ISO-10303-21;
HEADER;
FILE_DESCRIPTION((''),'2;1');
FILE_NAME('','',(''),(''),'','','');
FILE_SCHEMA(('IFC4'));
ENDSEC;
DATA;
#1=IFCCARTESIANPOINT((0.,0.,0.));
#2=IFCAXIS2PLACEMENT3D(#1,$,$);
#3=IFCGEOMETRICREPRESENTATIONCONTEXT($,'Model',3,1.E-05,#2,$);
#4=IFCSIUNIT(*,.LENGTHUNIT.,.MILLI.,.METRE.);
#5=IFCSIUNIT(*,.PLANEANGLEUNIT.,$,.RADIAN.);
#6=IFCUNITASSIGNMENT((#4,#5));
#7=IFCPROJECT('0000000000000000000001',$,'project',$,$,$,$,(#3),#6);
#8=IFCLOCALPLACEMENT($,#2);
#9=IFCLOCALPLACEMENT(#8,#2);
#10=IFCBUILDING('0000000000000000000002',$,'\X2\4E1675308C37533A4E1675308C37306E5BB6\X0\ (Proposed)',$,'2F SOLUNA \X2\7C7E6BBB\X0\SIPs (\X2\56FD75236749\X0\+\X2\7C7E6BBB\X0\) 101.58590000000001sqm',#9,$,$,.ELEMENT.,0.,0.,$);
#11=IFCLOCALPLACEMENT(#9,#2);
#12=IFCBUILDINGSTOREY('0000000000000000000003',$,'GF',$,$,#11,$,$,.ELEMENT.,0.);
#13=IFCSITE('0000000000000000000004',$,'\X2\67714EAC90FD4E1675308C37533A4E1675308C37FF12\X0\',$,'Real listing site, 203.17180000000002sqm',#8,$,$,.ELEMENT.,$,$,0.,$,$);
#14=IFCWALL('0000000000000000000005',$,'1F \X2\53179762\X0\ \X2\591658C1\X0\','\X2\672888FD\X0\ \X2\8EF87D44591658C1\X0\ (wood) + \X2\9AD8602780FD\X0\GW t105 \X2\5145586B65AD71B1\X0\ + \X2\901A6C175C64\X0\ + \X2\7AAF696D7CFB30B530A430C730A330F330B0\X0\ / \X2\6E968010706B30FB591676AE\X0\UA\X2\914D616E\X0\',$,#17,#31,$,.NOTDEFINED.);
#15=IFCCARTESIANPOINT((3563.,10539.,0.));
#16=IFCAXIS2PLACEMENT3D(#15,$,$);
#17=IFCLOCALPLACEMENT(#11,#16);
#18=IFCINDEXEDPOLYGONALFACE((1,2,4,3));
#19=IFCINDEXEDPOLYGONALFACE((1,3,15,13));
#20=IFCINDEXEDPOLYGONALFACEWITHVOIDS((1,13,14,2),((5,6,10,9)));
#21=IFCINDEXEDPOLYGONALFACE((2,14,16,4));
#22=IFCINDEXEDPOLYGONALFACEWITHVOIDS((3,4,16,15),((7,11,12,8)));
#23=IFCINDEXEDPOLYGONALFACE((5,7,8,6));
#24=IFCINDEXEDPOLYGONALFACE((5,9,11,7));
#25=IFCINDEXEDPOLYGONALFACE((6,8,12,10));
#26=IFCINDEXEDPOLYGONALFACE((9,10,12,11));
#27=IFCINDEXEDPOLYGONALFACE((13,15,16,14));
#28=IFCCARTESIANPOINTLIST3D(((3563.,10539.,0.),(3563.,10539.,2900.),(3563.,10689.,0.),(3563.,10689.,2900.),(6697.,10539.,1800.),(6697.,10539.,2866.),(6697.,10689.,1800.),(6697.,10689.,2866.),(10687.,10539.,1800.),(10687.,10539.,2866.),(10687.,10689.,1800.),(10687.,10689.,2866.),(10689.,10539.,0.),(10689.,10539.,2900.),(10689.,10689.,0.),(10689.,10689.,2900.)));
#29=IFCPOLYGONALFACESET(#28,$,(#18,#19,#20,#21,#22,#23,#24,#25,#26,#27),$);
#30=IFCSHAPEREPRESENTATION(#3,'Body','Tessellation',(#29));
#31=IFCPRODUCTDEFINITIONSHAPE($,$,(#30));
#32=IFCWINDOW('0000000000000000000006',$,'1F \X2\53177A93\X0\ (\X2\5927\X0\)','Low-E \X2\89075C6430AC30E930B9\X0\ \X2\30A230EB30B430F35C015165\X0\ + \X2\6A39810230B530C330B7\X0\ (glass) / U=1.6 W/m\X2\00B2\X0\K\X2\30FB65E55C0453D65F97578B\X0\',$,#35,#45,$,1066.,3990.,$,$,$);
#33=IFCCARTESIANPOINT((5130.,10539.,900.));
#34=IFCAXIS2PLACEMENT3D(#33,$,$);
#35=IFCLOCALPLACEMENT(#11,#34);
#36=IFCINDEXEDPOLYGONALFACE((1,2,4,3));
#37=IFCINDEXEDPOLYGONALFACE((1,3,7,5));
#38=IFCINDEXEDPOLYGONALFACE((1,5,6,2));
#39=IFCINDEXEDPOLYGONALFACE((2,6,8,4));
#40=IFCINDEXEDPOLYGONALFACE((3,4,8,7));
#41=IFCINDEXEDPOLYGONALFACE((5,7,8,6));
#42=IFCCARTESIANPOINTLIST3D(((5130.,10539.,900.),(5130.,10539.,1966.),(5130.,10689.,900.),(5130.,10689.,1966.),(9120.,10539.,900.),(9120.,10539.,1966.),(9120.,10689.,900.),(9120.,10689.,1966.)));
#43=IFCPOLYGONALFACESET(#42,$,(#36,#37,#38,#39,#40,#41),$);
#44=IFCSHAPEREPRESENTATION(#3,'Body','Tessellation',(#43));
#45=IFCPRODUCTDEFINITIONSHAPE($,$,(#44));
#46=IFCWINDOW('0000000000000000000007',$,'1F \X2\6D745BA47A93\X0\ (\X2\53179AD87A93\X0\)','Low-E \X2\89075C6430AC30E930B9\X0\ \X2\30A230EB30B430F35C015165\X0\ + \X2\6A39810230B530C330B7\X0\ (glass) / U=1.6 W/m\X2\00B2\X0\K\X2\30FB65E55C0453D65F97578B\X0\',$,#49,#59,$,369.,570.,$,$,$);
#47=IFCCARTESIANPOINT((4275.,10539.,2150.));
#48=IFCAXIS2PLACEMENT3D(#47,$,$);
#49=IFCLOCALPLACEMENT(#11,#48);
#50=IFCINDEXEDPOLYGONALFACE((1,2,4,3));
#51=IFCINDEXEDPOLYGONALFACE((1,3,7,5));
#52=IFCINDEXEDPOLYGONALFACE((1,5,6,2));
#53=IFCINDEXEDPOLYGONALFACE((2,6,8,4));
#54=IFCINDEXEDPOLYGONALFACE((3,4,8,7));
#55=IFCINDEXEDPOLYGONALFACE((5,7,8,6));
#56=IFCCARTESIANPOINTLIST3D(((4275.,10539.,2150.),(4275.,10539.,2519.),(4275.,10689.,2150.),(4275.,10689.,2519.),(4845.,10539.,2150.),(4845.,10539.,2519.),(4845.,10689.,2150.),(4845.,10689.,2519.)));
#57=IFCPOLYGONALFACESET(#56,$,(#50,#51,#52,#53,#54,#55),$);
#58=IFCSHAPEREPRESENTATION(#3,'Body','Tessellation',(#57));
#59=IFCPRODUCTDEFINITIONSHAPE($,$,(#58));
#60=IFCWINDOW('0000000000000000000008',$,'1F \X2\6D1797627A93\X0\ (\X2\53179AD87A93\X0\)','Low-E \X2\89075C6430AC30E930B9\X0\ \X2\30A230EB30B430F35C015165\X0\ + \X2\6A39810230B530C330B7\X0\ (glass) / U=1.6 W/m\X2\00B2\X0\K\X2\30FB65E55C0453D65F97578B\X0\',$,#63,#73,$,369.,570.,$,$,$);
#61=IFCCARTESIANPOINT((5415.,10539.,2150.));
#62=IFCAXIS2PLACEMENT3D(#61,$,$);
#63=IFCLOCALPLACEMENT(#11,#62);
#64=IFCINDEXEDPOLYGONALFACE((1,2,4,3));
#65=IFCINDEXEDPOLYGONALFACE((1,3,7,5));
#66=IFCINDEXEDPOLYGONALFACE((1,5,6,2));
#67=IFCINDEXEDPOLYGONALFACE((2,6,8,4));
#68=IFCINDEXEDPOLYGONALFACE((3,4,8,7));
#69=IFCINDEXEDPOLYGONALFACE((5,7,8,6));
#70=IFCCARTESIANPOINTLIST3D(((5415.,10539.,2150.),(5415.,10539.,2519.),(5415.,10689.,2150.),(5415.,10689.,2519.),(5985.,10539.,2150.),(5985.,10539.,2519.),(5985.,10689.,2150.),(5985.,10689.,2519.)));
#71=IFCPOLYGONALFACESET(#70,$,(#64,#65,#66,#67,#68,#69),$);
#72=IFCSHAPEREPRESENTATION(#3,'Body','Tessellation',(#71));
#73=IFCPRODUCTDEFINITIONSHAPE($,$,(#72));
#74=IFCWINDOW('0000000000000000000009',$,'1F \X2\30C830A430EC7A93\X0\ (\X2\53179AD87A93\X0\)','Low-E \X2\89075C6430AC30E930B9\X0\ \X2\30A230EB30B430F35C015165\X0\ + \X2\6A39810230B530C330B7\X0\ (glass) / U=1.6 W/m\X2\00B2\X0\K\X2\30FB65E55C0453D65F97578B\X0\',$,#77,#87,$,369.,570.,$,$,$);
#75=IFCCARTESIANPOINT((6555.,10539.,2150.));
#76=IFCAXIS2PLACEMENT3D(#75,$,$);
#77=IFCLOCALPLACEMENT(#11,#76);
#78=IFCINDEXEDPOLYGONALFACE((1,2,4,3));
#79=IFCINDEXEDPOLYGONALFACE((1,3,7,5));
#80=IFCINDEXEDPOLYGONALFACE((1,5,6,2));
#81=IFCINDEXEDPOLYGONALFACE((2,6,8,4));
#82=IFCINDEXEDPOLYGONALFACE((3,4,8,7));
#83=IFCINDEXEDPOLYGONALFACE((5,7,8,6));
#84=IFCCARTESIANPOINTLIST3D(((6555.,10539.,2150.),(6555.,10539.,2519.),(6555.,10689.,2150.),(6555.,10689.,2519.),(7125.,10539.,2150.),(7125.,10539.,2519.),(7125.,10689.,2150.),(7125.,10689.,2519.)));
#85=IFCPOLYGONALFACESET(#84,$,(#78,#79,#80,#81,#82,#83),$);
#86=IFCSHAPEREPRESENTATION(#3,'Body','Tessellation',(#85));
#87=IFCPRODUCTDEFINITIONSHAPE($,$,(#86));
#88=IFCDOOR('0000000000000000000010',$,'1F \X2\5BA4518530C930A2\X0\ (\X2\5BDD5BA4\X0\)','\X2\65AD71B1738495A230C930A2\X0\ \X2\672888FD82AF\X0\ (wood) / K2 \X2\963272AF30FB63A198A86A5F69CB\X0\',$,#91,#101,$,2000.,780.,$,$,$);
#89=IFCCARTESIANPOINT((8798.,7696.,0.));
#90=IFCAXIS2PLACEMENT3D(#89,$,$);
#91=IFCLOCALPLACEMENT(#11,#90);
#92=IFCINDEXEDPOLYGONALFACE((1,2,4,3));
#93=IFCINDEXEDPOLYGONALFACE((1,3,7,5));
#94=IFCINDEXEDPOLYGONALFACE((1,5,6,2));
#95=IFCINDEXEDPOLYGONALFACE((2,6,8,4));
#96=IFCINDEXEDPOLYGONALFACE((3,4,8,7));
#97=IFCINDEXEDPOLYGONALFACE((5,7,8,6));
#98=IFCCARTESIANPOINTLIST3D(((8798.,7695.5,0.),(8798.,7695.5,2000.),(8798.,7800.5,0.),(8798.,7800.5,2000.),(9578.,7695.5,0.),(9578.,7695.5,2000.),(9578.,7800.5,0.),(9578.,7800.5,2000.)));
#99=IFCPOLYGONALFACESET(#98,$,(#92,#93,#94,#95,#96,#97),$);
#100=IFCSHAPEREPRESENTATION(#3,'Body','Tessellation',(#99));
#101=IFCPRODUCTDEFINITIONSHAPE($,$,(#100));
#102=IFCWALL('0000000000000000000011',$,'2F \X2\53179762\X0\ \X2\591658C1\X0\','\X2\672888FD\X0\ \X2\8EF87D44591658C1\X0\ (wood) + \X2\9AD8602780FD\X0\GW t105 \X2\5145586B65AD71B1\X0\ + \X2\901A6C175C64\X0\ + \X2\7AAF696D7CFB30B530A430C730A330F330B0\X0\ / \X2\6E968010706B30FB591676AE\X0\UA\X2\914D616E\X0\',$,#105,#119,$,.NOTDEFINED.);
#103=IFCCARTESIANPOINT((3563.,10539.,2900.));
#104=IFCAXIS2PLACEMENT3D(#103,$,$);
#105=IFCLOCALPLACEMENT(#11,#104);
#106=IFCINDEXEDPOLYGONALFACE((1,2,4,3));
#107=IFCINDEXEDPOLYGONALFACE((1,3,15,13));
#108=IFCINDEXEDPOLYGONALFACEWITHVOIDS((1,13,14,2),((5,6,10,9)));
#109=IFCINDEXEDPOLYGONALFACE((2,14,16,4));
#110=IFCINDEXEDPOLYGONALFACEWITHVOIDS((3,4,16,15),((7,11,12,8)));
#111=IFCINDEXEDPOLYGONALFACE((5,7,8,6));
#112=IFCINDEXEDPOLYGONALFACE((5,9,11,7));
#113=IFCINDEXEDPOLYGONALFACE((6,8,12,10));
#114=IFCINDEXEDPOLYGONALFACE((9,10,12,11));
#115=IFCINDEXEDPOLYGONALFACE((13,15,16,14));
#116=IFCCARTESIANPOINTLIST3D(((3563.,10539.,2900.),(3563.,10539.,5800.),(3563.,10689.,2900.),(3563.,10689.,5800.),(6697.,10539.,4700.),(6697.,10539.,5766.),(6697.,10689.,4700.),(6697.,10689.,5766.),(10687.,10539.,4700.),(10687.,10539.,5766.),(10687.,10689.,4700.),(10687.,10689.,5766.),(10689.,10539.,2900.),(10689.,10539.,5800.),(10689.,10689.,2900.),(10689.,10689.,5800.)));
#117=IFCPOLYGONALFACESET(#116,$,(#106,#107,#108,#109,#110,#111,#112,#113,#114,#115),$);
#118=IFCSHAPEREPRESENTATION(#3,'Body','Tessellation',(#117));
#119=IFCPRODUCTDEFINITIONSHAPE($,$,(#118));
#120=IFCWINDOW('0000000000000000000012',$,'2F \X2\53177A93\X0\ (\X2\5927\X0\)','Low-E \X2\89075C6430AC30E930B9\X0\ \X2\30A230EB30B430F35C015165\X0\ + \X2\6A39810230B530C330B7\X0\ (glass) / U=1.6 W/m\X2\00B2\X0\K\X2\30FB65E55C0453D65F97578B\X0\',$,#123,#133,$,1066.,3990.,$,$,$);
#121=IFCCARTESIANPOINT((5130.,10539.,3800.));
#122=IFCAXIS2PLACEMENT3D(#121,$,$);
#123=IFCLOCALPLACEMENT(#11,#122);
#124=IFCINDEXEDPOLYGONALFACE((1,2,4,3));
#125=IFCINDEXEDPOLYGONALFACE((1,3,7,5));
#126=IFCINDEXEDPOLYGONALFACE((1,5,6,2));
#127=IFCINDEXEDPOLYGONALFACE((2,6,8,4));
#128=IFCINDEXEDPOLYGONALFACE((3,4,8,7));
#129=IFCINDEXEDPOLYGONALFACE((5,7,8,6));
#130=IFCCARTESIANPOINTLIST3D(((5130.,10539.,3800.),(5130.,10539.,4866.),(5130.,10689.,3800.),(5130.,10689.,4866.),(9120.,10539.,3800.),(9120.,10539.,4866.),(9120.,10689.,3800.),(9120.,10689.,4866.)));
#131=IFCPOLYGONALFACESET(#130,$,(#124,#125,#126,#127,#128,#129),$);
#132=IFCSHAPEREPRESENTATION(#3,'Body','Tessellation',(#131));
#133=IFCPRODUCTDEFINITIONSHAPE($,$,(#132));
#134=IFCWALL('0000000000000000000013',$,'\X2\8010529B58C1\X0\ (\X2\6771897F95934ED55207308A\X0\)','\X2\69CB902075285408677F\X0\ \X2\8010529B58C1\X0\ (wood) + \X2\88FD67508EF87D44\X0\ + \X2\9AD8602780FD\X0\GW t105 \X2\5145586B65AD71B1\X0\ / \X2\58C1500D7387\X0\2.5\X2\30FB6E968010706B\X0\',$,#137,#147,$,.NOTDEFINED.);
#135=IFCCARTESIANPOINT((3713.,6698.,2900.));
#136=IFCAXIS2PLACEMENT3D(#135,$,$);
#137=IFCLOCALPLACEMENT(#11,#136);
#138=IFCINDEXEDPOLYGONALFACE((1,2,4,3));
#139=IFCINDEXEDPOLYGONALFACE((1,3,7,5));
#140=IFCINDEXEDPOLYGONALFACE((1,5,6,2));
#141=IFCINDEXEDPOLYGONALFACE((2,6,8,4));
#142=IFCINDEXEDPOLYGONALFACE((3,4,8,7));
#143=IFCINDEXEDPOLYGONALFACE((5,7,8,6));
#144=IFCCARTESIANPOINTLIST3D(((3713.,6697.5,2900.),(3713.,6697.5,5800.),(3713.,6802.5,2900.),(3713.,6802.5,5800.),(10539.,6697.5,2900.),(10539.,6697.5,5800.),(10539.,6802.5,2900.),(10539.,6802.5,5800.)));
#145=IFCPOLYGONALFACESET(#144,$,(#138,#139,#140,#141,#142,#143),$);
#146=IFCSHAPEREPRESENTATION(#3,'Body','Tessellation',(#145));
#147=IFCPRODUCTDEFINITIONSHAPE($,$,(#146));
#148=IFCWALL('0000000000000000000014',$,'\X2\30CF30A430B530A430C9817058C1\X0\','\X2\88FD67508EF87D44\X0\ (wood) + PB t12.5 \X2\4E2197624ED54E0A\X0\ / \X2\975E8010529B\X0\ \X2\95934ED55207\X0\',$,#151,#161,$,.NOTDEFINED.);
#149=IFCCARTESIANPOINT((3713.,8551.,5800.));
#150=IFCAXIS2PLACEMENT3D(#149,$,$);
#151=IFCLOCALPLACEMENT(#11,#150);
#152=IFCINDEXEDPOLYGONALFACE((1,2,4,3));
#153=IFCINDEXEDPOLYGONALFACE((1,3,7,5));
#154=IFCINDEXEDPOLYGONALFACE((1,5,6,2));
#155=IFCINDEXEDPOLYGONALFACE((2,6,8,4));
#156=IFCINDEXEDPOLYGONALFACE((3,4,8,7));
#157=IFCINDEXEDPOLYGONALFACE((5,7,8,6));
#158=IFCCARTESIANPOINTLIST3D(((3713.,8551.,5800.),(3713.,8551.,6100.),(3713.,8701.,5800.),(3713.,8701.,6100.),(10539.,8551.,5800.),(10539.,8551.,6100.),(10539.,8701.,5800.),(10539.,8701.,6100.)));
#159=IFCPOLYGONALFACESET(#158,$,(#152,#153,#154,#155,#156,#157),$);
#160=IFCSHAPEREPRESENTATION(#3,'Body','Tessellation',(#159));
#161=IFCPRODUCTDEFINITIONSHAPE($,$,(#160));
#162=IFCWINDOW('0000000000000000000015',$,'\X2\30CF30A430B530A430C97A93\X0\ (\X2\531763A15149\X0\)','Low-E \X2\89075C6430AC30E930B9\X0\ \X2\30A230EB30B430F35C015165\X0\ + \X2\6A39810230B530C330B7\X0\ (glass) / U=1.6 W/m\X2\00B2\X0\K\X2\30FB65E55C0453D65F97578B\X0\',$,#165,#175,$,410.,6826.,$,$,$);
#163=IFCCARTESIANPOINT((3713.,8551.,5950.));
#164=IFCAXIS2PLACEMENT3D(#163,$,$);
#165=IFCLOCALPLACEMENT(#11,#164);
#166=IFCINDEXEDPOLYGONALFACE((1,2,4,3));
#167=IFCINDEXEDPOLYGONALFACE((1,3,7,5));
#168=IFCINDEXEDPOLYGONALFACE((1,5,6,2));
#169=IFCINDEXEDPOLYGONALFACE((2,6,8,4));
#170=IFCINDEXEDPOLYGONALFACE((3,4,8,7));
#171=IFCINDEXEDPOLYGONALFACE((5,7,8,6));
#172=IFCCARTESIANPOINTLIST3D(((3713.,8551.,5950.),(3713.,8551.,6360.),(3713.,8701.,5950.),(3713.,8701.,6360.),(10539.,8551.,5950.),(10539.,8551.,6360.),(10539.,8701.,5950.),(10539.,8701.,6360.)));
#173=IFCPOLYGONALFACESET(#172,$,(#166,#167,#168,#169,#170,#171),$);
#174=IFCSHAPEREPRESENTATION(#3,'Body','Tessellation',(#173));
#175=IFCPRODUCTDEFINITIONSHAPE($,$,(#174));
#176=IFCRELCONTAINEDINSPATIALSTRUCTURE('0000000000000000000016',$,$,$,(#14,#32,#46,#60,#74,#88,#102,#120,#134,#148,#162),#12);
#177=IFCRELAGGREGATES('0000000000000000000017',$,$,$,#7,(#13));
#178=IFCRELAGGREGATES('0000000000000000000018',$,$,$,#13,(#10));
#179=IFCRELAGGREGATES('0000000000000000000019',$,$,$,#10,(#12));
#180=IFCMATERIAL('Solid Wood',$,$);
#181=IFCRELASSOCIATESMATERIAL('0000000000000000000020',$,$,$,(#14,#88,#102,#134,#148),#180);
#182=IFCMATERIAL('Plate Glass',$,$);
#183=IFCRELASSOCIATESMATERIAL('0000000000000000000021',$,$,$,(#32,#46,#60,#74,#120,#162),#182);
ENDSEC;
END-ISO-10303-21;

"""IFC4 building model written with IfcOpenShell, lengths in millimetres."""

from ifc_helpers import new_model, si_unit, frame, frame_2d, origin, place, context, project, spatial, rectangle, extrude, material, element, fill, save


model = new_model("IFC4")

# Units and contexts
model_context = context("Model", 3, precision=1e-05, world=origin())
ifc_project = project(units=[si_unit("LENGTHUNIT", "METRE", prefix="MILLI"), si_unit("PLANEANGLEUNIT", "RADIAN")], contexts=[model_context])

# Site, building, storey
site_placement = place(None, origin())
site = spatial("IfcSite", under=ifc_project, at=site_placement, Name="東京都世田谷区世田谷２", ObjectType="Real listing site, 203.17180000000002sqm", CompositionType="ELEMENT", RefElevation=0.0)
building_placement = place(site_placement, origin())
building = spatial("IfcBuilding", under=site, at=building_placement, Name="世田谷区世田谷の家 (Proposed)", ObjectType="2F SOLUNA 籾殻SIPs (国産杉+籾殻) 101.58590000000001sqm", CompositionType="ELEMENT", ElevationOfRefHeight=0.0, ElevationOfTerrain=0.0)
storey_placement = place(building_placement, origin())
storey = spatial("IfcBuildingStorey", under=building, at=storey_placement, Name="GF", CompositionType="ELEMENT", Elevation=0.0)

# Wall, openings, windows
ifc_material_1 = material(Name="Solid Wood")
wall_1_placement = place(storey_placement, frame((3563.0, 10539.0, 0.0)))
wall_1 = element("IfcWall", 1, at=wall_1_placement, inside=storey, material=ifc_material_1, Name="1F 北面 外壁", Description="木製 軸組外壁 (wood) + 高性能GW t105 充填断熱 + 通気層 + 窯業系サイディング / 準耐火・外皮UA配慮", PredefinedType="NOTDEFINED", context=model_context, shape_type="SweptSolid", body=[
    extrude(rectangle(XDim=7126.0, YDim=150.0, at=frame_2d((3563.0, 75.0))), frame((3563.0, 10539.0, 0.0)), (0.0, 0.0, 1.0), 2900.0),
])
opening_1_placement = place(storey_placement, frame((5130.0, 10539.0, 900.0)))
opening_1 = element("IfcOpeningElement", 2, at=opening_1_placement, cuts=wall_1, PredefinedType="NOTDEFINED", context=model_context, shape_type="SweptSolid", body=[
    extrude(rectangle(XDim=3990.0, YDim=150.0, at=frame_2d((1995.0, 75.0))), frame((5130.0, 10539.0, 900.0)), (0.0, 0.0, 1.0), 1066.0),
])
opening_2_placement = place(storey_placement, frame((4275.0, 10539.0, 2150.0)))
opening_2 = element("IfcOpeningElement", 3, at=opening_2_placement, cuts=wall_1, PredefinedType="NOTDEFINED", context=model_context, shape_type="SweptSolid", body=[
    extrude(rectangle(XDim=570.0, YDim=150.0, at=frame_2d((285.0, 75.0))), frame((4275.0, 10539.0, 2150.0)), (0.0, 0.0, 1.0), 369.0),
])
opening_3_placement = place(storey_placement, frame((5415.0, 10539.0, 2150.0)))
opening_3 = element("IfcOpeningElement", 4, at=opening_3_placement, cuts=wall_1, PredefinedType="NOTDEFINED", context=model_context, shape_type="SweptSolid", body=[
    extrude(rectangle(XDim=570.0, YDim=150.0, at=frame_2d((285.0, 75.0))), frame((5415.0, 10539.0, 2150.0)), (0.0, 0.0, 1.0), 369.0),
])
opening_4_placement = place(storey_placement, frame((6555.0, 10539.0, 2150.0)))
opening_4 = element("IfcOpeningElement", 5, at=opening_4_placement, cuts=wall_1, PredefinedType="NOTDEFINED", context=model_context, shape_type="SweptSolid", body=[
    extrude(rectangle(XDim=570.0, YDim=150.0, at=frame_2d((285.0, 75.0))), frame((6555.0, 10539.0, 2150.0)), (0.0, 0.0, 1.0), 369.0),
])
ifc_material_2 = material(Name="Plate Glass")
window_1_placement = place(storey_placement, frame((5130.0, 10539.0, 900.0)))
window_1 = element("IfcWindow", 6, at=window_1_placement, inside=storey, material=ifc_material_2, Name="1F 北窓 (大)", Description="Low-E 複層ガラス アルゴン封入 + 樹脂サッシ (glass) / U=1.6 W/m²K・日射取得型", OverallHeight=1066.0, OverallWidth=3990.0, context=model_context, shape_type="SweptSolid", body=[
    extrude(rectangle(XDim=3990.0, YDim=150.0, at=frame_2d((1995.0, 75.0))), frame((5130.0, 10539.0, 900.0)), (0.0, 0.0, 1.0), 1066.0),
])
fill(opening_1, window_1)
window_2_placement = place(storey_placement, frame((4275.0, 10539.0, 2150.0)))
window_2 = element("IfcWindow", 7, at=window_2_placement, inside=storey, material=ifc_material_2, Name="1F 浴室窓 (北高窓)", Description="Low-E 複層ガラス アルゴン封入 + 樹脂サッシ (glass) / U=1.6 W/m²K・日射取得型", OverallHeight=369.0, OverallWidth=570.0, context=model_context, shape_type="SweptSolid", body=[
    extrude(rectangle(XDim=570.0, YDim=150.0, at=frame_2d((285.0, 75.0))), frame((4275.0, 10539.0, 2150.0)), (0.0, 0.0, 1.0), 369.0),
])
fill(opening_2, window_2)
window_3_placement = place(storey_placement, frame((5415.0, 10539.0, 2150.0)))
window_3 = element("IfcWindow", 8, at=window_3_placement, inside=storey, material=ifc_material_2, Name="1F 洗面窓 (北高窓)", Description="Low-E 複層ガラス アルゴン封入 + 樹脂サッシ (glass) / U=1.6 W/m²K・日射取得型", OverallHeight=369.0, OverallWidth=570.0, context=model_context, shape_type="SweptSolid", body=[
    extrude(rectangle(XDim=570.0, YDim=150.0, at=frame_2d((285.0, 75.0))), frame((5415.0, 10539.0, 2150.0)), (0.0, 0.0, 1.0), 369.0),
])
fill(opening_3, window_3)
window_4_placement = place(storey_placement, frame((6555.0, 10539.0, 2150.0)))
window_4 = element("IfcWindow", 9, at=window_4_placement, inside=storey, material=ifc_material_2, Name="1F トイレ窓 (北高窓)", Description="Low-E 複層ガラス アルゴン封入 + 樹脂サッシ (glass) / U=1.6 W/m²K・日射取得型", OverallHeight=369.0, OverallWidth=570.0, context=model_context, shape_type="SweptSolid", body=[
    extrude(rectangle(XDim=570.0, YDim=150.0, at=frame_2d((285.0, 75.0))), frame((6555.0, 10539.0, 2150.0)), (0.0, 0.0, 1.0), 369.0),
])
fill(opening_4, window_4)

# Door
door_1_placement = place(storey_placement, frame((8798.0, 7696.0, 0.0)))
element("IfcDoor", 10, at=door_1_placement, inside=storey, material=ifc_material_1, Name="1F 室内ドア (寝室)", Description="断熱玄関ドア 木製芯 (wood) / K2 防犯・採風機構", OverallHeight=2000.0, OverallWidth=780.0, context=model_context, shape_type="SweptSolid", body=[
    extrude(rectangle(XDim=780.0, YDim=105.0, at=frame_2d((390.0, 52.0))), frame((8798.0, 7696.0, 0.0)), (0.0, 0.0, 1.0), 2000.0),
])

# Wall, opening, window
wall_2_placement = place(storey_placement, frame((3563.0, 10539.0, 2900.0)))
wall_2 = element("IfcWall", 11, at=wall_2_placement, inside=storey, material=ifc_material_1, Name="2F 北面 外壁", Description="木製 軸組外壁 (wood) + 高性能GW t105 充填断熱 + 通気層 + 窯業系サイディング / 準耐火・外皮UA配慮", PredefinedType="NOTDEFINED", context=model_context, shape_type="SweptSolid", body=[
    extrude(rectangle(XDim=7126.0, YDim=150.0, at=frame_2d((3563.0, 75.0))), frame((3563.0, 10539.0, 2900.0)), (0.0, 0.0, 1.0), 2900.0),
])
opening_5_placement = place(storey_placement, frame((5130.0, 10539.0, 3800.0)))
opening_5 = element("IfcOpeningElement", 12, at=opening_5_placement, cuts=wall_2, PredefinedType="NOTDEFINED", context=model_context, shape_type="SweptSolid", body=[
    extrude(rectangle(XDim=3990.0, YDim=150.0, at=frame_2d((1995.0, 75.0))), frame((5130.0, 10539.0, 3800.0)), (0.0, 0.0, 1.0), 1066.0),
])
window_5_placement = place(storey_placement, frame((5130.0, 10539.0, 3800.0)))
window_5 = element("IfcWindow", 13, at=window_5_placement, inside=storey, material=ifc_material_2, Name="2F 北窓 (大)", Description="Low-E 複層ガラス アルゴン封入 + 樹脂サッシ (glass) / U=1.6 W/m²K・日射取得型", OverallHeight=1066.0, OverallWidth=3990.0, context=model_context, shape_type="SweptSolid", body=[
    extrude(rectangle(XDim=3990.0, YDim=150.0, at=frame_2d((1995.0, 75.0))), frame((5130.0, 10539.0, 3800.0)), (0.0, 0.0, 1.0), 1066.0),
])
fill(opening_5, window_5)

# Wall
wall_3_placement = place(storey_placement, frame((3713.0, 6698.0, 2900.0)))
element("IfcWall", 14, at=wall_3_placement, inside=storey, material=ifc_material_1, Name="耐力壁 (東西間仕切り)", Description="構造用合板 耐力壁 (wood) + 製材軸組 + 高性能GW t105 充填断熱 / 壁倍率2.5・準耐火", PredefinedType="NOTDEFINED", context=model_context, shape_type="SweptSolid", body=[
    extrude(rectangle(XDim=6826.0, YDim=105.0, at=frame_2d((3413.0, 52.0))), frame((3713.0, 6698.0, 2900.0)), (0.0, 0.0, 1.0), 2900.0),
])

# Wall, opening, window
wall_4_placement = place(storey_placement, frame((3713.0, 8551.0, 5800.0)))
wall_4 = element("IfcWall", 15, at=wall_4_placement, inside=storey, material=ifc_material_1, Name="ハイサイド腰壁", Description="製材軸組 (wood) + PB t12.5 両面仕上 / 非耐力 間仕切", PredefinedType="NOTDEFINED", context=model_context, shape_type="SweptSolid", body=[
    extrude(rectangle(XDim=6826.0, YDim=150.0, at=frame_2d((3413.0, 75.0))), frame((3713.0, 8551.0, 5800.0)), (0.0, 0.0, 1.0), 700.0),
])
opening_6_placement = place(storey_placement, frame((3713.0, 8551.0, 5950.0)))
opening_6 = element("IfcOpeningElement", 16, at=opening_6_placement, cuts=wall_4, PredefinedType="NOTDEFINED", context=model_context, shape_type="SweptSolid", body=[
    extrude(rectangle(XDim=6826.0, YDim=150.0, at=frame_2d((3413.0, 75.0))), frame((3713.0, 8551.0, 5950.0)), (0.0, 0.0, 1.0), 410.0),
])
window_6_placement = place(storey_placement, frame((3713.0, 8551.0, 5950.0)))
window_6 = element("IfcWindow", 17, at=window_6_placement, inside=storey, material=ifc_material_2, Name="ハイサイド窓 (北採光)", Description="Low-E 複層ガラス アルゴン封入 + 樹脂サッシ (glass) / U=1.6 W/m²K・日射取得型", OverallHeight=410.0, OverallWidth=6826.0, context=model_context, shape_type="SweptSolid", body=[
    extrude(rectangle(XDim=6826.0, YDim=150.0, at=frame_2d((3413.0, 75.0))), frame((3713.0, 8551.0, 5950.0)), (0.0, 0.0, 1.0), 410.0),
])
fill(opening_6, window_6)

save(model, "model.ifc")
